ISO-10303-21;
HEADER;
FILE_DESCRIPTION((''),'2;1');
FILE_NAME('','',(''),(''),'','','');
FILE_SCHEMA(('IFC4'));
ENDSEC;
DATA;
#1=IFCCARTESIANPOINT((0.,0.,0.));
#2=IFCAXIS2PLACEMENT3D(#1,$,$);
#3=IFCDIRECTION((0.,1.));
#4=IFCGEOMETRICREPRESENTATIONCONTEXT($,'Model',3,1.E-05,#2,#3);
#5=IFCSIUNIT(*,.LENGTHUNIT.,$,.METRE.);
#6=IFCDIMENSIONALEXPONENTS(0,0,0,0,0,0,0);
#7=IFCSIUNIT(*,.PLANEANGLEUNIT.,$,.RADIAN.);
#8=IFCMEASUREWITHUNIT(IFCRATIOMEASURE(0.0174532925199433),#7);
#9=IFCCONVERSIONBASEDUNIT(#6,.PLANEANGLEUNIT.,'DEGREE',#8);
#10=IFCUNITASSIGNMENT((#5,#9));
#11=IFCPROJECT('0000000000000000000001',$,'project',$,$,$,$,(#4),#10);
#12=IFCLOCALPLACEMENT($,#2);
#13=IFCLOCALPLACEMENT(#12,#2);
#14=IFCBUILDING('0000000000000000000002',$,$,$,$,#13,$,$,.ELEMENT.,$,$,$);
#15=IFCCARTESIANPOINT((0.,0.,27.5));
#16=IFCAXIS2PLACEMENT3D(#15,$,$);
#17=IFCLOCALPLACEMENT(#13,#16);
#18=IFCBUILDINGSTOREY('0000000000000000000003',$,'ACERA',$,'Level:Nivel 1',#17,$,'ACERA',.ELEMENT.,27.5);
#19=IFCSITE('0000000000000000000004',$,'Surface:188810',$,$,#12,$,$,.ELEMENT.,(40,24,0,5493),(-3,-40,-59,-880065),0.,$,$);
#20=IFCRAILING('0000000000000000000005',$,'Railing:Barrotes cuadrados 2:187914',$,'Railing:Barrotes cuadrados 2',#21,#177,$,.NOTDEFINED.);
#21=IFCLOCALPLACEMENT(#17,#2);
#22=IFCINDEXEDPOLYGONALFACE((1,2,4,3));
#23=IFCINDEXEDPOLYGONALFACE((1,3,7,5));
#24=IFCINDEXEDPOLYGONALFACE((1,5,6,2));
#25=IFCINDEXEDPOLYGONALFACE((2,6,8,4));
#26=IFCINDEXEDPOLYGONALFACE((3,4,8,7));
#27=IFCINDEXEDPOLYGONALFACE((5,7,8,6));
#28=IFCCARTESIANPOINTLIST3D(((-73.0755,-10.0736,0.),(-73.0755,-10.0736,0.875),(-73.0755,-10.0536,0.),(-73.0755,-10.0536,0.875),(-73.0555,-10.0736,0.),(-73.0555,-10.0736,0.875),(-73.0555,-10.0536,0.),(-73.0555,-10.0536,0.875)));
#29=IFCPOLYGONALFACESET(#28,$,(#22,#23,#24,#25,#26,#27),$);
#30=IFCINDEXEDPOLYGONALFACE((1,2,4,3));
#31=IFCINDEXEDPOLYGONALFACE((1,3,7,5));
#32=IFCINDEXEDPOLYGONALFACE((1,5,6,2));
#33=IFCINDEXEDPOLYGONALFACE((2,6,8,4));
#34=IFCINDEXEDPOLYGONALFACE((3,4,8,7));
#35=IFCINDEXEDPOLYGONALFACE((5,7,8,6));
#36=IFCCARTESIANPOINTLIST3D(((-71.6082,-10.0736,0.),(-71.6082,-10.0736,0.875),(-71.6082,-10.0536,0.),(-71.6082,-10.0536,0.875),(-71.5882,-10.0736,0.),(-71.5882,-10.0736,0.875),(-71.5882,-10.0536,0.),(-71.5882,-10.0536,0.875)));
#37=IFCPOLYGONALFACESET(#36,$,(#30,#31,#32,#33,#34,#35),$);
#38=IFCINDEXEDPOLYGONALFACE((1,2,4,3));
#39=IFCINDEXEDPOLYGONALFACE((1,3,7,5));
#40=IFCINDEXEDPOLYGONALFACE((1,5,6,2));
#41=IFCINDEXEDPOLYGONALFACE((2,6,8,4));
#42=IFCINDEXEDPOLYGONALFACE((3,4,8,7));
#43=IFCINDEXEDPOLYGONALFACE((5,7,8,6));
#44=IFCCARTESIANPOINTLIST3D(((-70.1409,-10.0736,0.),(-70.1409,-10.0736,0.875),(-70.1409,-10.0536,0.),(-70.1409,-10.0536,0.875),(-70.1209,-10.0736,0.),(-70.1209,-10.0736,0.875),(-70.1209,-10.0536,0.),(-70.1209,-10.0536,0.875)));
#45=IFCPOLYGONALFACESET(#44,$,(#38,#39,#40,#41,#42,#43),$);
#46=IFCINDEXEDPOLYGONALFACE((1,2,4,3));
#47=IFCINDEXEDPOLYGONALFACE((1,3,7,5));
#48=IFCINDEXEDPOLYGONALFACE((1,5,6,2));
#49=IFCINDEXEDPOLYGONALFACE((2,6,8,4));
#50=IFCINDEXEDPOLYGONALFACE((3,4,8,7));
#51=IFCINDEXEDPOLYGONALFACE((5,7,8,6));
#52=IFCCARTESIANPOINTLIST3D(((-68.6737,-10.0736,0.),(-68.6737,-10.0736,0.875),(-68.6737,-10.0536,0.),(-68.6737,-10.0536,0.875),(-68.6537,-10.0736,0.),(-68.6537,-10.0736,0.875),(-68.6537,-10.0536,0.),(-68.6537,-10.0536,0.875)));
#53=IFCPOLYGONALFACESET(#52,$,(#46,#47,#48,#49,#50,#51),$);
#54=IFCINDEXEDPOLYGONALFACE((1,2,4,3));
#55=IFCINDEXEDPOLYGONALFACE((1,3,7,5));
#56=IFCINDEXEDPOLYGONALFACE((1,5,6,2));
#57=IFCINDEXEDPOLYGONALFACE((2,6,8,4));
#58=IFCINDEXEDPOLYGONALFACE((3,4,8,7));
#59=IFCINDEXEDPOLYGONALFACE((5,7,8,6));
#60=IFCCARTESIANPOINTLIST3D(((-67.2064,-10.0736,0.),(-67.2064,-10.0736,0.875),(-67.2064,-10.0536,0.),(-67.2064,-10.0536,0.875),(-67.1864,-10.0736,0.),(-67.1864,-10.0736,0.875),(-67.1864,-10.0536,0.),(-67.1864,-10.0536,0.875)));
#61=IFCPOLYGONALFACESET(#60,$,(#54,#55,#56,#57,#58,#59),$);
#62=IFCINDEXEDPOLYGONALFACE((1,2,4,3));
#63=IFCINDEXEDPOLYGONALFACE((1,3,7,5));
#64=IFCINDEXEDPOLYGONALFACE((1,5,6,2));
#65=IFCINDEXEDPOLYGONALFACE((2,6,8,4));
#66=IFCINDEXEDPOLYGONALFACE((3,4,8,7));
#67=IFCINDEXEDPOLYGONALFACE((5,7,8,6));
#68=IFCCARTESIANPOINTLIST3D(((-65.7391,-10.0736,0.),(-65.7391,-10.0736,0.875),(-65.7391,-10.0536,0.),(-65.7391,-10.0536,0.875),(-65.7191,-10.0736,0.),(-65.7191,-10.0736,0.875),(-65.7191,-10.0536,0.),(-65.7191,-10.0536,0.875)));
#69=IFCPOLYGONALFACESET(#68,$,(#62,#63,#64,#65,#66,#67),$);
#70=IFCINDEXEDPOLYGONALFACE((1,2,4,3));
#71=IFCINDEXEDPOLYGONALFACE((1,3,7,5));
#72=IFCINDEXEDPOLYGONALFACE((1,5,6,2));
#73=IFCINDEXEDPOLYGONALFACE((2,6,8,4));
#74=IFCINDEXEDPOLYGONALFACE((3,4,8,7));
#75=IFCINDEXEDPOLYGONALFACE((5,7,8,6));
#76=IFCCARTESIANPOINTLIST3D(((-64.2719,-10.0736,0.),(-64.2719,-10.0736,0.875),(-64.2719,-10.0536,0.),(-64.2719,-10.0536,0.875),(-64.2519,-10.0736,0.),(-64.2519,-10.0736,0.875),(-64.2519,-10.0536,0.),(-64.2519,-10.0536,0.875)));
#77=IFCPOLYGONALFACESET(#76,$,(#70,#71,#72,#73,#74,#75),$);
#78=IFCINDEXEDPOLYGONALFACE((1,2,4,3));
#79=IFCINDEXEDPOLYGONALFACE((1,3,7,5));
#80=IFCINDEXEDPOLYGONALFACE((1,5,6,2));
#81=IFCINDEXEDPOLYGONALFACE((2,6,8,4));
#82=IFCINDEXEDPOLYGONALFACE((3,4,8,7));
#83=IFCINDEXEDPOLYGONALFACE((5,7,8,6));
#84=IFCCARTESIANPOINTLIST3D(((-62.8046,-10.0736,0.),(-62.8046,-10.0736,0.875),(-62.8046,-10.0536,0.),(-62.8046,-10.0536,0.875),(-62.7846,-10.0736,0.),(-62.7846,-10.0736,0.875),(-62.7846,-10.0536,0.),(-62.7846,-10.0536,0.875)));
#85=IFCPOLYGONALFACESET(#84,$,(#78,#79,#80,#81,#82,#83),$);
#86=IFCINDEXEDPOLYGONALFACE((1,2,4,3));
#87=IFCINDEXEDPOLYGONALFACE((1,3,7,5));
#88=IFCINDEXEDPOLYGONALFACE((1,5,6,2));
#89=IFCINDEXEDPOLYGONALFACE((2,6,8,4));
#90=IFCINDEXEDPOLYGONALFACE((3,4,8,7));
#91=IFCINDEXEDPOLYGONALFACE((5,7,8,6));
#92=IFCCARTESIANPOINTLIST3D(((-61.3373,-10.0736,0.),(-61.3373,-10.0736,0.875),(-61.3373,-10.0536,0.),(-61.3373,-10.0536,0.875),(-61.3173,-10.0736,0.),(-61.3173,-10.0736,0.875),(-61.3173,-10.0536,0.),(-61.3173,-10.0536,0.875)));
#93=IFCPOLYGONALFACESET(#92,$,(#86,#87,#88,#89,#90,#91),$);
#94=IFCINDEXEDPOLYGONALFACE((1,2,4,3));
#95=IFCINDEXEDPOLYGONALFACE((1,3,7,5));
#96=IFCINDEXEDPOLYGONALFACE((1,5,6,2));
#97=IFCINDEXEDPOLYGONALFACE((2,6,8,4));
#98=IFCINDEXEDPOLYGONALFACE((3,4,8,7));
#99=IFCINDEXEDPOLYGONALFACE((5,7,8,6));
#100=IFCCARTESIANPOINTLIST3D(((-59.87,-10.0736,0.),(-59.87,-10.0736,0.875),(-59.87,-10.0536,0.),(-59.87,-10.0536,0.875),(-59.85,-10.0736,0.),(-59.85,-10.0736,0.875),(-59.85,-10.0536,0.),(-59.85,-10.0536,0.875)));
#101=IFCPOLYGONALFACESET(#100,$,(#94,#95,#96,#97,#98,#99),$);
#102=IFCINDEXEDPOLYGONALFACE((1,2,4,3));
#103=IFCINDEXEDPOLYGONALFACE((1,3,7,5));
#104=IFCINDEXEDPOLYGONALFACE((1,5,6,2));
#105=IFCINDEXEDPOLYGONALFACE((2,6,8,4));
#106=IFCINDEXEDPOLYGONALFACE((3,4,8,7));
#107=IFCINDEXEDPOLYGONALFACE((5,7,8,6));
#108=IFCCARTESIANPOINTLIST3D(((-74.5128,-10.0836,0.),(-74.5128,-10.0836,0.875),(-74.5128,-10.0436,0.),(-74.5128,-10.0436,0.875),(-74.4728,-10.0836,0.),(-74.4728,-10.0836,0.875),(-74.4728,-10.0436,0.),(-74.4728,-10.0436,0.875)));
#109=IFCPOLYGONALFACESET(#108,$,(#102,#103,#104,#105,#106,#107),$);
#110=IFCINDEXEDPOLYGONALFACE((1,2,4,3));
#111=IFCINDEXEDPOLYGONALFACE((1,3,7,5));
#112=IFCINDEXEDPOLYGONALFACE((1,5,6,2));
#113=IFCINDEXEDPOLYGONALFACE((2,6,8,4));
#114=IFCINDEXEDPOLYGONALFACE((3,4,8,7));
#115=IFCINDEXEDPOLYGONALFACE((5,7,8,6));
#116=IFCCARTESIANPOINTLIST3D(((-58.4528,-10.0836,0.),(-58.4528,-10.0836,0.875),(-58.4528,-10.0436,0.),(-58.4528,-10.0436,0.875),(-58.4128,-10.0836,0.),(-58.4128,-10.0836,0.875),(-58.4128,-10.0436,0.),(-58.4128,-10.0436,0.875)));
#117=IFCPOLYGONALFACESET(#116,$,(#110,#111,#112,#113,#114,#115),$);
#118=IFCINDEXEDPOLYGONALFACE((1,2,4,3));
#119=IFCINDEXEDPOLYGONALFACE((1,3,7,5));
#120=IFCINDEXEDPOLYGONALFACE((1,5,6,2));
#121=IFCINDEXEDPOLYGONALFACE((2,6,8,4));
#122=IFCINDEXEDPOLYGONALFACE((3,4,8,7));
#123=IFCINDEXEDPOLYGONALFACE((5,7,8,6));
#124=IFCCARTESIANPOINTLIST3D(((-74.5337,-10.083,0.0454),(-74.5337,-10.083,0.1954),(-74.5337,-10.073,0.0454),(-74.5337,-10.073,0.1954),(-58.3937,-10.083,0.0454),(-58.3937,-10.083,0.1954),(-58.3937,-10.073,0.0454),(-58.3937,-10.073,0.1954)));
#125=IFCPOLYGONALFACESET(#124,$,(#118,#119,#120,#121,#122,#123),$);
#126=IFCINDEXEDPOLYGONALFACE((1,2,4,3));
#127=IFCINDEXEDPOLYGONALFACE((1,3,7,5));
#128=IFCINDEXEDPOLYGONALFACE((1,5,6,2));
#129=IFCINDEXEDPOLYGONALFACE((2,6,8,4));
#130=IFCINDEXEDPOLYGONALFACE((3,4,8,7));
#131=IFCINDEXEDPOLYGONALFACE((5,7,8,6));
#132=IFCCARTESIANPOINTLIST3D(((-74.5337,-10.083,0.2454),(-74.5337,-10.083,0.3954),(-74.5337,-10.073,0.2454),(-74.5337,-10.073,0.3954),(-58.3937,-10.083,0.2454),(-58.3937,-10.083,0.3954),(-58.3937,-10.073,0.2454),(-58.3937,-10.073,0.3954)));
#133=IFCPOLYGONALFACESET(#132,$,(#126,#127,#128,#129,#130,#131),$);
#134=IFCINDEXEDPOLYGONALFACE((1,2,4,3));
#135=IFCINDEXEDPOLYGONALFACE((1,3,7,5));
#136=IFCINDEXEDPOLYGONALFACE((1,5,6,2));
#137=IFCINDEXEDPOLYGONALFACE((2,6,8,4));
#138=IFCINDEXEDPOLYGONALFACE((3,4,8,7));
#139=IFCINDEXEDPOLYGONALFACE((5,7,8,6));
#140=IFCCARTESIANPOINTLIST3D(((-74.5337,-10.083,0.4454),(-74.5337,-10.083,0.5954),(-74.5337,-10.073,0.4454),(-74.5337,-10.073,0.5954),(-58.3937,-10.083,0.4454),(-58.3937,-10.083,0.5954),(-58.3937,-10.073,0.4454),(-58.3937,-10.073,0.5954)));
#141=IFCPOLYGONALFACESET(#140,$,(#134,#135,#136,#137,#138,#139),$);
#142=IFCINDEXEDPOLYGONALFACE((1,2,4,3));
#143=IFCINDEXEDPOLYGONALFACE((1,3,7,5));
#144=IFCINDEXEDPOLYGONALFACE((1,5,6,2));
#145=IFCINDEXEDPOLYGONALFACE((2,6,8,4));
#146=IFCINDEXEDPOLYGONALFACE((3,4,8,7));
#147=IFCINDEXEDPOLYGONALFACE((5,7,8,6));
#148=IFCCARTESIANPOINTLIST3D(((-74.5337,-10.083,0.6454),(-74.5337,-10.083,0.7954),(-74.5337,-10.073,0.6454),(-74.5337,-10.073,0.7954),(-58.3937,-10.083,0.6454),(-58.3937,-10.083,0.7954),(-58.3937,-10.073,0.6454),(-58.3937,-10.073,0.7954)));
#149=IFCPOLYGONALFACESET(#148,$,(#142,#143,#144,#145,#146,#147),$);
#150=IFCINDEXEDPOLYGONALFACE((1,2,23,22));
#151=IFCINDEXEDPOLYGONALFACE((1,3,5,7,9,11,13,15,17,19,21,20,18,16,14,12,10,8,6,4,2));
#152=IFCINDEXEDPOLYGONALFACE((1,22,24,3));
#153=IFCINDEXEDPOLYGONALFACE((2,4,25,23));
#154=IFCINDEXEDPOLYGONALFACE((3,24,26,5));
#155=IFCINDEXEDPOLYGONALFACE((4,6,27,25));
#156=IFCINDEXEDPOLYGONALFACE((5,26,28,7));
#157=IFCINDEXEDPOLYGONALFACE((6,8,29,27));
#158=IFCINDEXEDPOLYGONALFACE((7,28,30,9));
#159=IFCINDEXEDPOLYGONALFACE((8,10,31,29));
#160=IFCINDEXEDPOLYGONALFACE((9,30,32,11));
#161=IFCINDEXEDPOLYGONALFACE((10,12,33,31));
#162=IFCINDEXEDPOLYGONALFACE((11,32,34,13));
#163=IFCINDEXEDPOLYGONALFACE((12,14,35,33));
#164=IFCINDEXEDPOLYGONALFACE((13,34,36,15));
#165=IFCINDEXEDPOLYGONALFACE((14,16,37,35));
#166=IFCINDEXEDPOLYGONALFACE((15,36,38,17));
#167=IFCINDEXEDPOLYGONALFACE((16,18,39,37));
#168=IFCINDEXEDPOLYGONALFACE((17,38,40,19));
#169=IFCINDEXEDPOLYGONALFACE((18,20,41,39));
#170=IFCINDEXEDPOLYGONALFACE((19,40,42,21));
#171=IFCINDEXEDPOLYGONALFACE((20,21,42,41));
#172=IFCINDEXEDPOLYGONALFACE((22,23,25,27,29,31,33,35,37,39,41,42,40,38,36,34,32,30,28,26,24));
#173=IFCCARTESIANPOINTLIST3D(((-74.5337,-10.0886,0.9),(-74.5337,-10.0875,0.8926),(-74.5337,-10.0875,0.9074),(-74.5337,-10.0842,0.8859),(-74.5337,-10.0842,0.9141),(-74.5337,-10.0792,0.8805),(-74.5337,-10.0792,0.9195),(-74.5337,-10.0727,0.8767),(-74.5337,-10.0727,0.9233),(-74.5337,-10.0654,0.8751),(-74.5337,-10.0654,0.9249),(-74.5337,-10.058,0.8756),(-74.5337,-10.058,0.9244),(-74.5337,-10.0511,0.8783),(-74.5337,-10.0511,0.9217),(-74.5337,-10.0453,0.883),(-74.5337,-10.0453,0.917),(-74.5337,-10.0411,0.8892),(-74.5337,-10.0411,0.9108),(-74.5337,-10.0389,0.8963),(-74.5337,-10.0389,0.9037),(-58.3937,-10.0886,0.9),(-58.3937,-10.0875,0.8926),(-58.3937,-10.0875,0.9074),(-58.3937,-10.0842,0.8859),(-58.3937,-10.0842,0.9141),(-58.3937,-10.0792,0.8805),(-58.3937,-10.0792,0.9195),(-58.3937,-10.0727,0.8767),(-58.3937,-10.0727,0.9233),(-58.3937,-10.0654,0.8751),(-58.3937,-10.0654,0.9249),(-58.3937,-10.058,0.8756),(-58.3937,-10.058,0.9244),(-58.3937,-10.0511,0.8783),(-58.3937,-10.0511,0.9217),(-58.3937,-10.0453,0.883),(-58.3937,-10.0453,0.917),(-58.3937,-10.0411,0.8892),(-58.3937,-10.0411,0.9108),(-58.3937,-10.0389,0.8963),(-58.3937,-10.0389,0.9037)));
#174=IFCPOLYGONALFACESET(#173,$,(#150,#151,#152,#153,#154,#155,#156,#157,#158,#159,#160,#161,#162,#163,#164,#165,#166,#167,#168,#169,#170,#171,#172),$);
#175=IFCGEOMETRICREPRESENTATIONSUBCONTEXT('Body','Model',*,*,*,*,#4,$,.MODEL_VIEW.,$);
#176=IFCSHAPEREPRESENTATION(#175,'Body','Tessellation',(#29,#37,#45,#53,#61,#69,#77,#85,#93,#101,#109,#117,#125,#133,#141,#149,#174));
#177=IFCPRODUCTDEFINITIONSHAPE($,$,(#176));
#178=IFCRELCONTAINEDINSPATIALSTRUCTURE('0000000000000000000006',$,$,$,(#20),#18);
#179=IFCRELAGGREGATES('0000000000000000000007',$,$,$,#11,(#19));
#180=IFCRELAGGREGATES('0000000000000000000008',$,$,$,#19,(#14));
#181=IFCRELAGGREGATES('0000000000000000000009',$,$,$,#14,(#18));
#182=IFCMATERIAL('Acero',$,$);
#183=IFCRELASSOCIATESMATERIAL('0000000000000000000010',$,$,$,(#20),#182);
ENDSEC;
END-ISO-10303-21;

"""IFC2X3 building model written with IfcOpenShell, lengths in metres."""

from ifc_helpers import new_model, entity, si_unit, converted_unit, direction, frame, frame_2d, origin, origin_2d_with_axis, place, context, subcontext, project, spatial, rectangle, circle, extrude, material, element, save


model = new_model("IFC2X3")

# Units and contexts
model_context = context("Model", 3, precision=1e-05, world=origin(), true_north=direction((0.0, 1.0)))
body_context = subcontext(model_context, "Body", "Model", "MODEL_VIEW")
ifc_project = project(units=[si_unit("LENGTHUNIT", "METRE"), converted_unit("PLANEANGLEUNIT", "DEGREE", entity("IfcRatioMeasure", 0.0174532925199433), si_unit("PLANEANGLEUNIT", "RADIAN"), dimensions=[0, 0, 0, 0, 0, 0, 0])], contexts=[model_context])

# Site, building, storey
site_placement = place(None, origin())
site = spatial("IfcSite", under=ifc_project, at=site_placement, Name="Surface:188810", CompositionType="ELEMENT", RefLatitude=(40, 24, 0, 5493), RefLongitude=(-3, -40, -59, -880065), RefElevation=0.0)
building_placement = place(site_placement, origin())
building = spatial("IfcBuilding", under=site, at=building_placement, CompositionType="ELEMENT")
storey_placement = place(building_placement, frame((0.0, 0.0, 27.5)))
storey = spatial("IfcBuildingStorey", under=building, at=storey_placement, Name="ACERA", ObjectType="Level:Nivel 1", LongName="ACERA", CompositionType="ELEMENT", Elevation=27.5)

# Railing
ifc_material_1 = material(Name="Acero")
railing_1_placement = place(storey_placement, origin())
element("IfcRailing", 1, at=railing_1_placement, inside=storey, material=ifc_material_1, Name="Railing:Barrotes cuadrados 2:187914", ObjectType="Railing:Barrotes cuadrados 2", PredefinedType="NOTDEFINED", context=body_context, shape_type="SweptSolid", body=[
    extrude(rectangle(XDim=0.02, YDim=0.02, at=frame_2d((0.0, 0.0), x_axis=(1.0, 0.0))), frame((-73.0655, -10.0636, 0.0), z_axis=(0.0, 0.0, 1.0), x_axis=(-1.0, 0.0, 0.0)), (0.0, 0.0, 1.0), 0.875),
    extrude(rectangle(XDim=0.02, YDim=0.02, at=frame_2d((0.0, 0.0), x_axis=(1.0, 0.0))), frame((-71.5982, -10.0636, 0.0), z_axis=(0.0, 0.0, 1.0), x_axis=(-1.0, 0.0, 0.0)), (0.0, 0.0, 1.0), 0.875),
    extrude(rectangle(XDim=0.02, YDim=0.02, at=frame_2d((0.0, 0.0), x_axis=(1.0, 0.0))), frame((-70.1309, -10.0636, 0.0), z_axis=(0.0, 0.0, 1.0), x_axis=(-1.0, 0.0, 0.0)), (0.0, 0.0, 1.0), 0.875),
    extrude(rectangle(XDim=0.02, YDim=0.02, at=frame_2d((0.0, 0.0), x_axis=(1.0, 0.0))), frame((-68.6637, -10.0636, 0.0), z_axis=(0.0, 0.0, 1.0), x_axis=(-1.0, 0.0, 0.0)), (0.0, 0.0, 1.0), 0.875),
    extrude(rectangle(XDim=0.02, YDim=0.02, at=frame_2d((0.0, 0.0), x_axis=(1.0, 0.0))), frame((-67.1964, -10.0636, 0.0), z_axis=(0.0, 0.0, 1.0), x_axis=(-1.0, 0.0, 0.0)), (0.0, 0.0, 1.0), 0.875),
    extrude(rectangle(XDim=0.02, YDim=0.02, at=frame_2d((0.0, 0.0), x_axis=(1.0, 0.0))), frame((-65.7291, -10.0636, 0.0), z_axis=(0.0, 0.0, 1.0), x_axis=(-1.0, 0.0, 0.0)), (0.0, 0.0, 1.0), 0.875),
    extrude(rectangle(XDim=0.02, YDim=0.02, at=frame_2d((0.0, 0.0), x_axis=(1.0, 0.0))), frame((-64.2619, -10.0636, 0.0), z_axis=(0.0, 0.0, 1.0), x_axis=(-1.0, 0.0, 0.0)), (0.0, 0.0, 1.0), 0.875),
    extrude(rectangle(XDim=0.02, YDim=0.02, at=frame_2d((0.0, 0.0), x_axis=(1.0, 0.0))), frame((-62.7946, -10.0636, 0.0), z_axis=(0.0, 0.0, 1.0), x_axis=(-1.0, 0.0, 0.0)), (0.0, 0.0, 1.0), 0.875),
    extrude(rectangle(XDim=0.02, YDim=0.02, at=frame_2d((0.0, 0.0), x_axis=(1.0, 0.0))), frame((-61.3273, -10.0636, 0.0), z_axis=(0.0, 0.0, 1.0), x_axis=(-1.0, 0.0, 0.0)), (0.0, 0.0, 1.0), 0.875),
    extrude(rectangle(XDim=0.02, YDim=0.02, at=frame_2d((0.0, 0.0), x_axis=(1.0, 0.0))), frame((-59.86, -10.0636, 0.0), z_axis=(0.0, 0.0, 1.0), x_axis=(-1.0, 0.0, 0.0)), (0.0, 0.0, 1.0), 0.875),
    extrude(rectangle(XDim=0.04, YDim=0.04, at=frame_2d((0.0, 0.0), x_axis=(1.0, 0.0))), frame((-74.4928, -10.0636, 0.0), z_axis=(0.0, 0.0, 1.0), x_axis=(-1.0, 0.0, 0.0)), (0.0, 0.0, 1.0), 0.875),
    extrude(rectangle(XDim=0.04, YDim=0.04, at=frame_2d((0.0, 0.0), x_axis=(1.0, 0.0))), frame((-58.4328, -10.0636, 0.0), z_axis=(0.0, 0.0, 1.0), x_axis=(-1.0, 0.0, 0.0)), (0.0, 0.0, 1.0), 0.875),
    extrude(rectangle(XDim=16.14, YDim=0.01, at=frame_2d((0.0, 0.0), x_axis=(1.0, 0.0))), frame((-66.4637, -10.078, 0.0454), z_axis=(0.0, 0.0, 1.0), x_axis=(-1.0, 0.0, 0.0)), (0.0, 0.0, 1.0), 0.15),
    extrude(rectangle(XDim=16.14, YDim=0.01, at=frame_2d((0.0, 0.0), x_axis=(1.0, 0.0))), frame((-66.4637, -10.078, 0.2454), z_axis=(0.0, 0.0, 1.0), x_axis=(-1.0, 0.0, 0.0)), (0.0, 0.0, 1.0), 0.15),
    extrude(rectangle(XDim=16.14, YDim=0.01, at=frame_2d((0.0, 0.0), x_axis=(1.0, 0.0))), frame((-66.4637, -10.078, 0.4454), z_axis=(0.0, 0.0, 1.0), x_axis=(-1.0, 0.0, 0.0)), (0.0, 0.0, 1.0), 0.15),
    extrude(rectangle(XDim=16.14, YDim=0.01, at=frame_2d((0.0, 0.0), x_axis=(1.0, 0.0))), frame((-66.4637, -10.078, 0.6454), z_axis=(0.0, 0.0, 1.0), x_axis=(-1.0, 0.0, 0.0)), (0.0, 0.0, 1.0), 0.15),
    extrude(circle(Radius=0.025, at=origin_2d_with_axis()), frame((-74.5337, -10.0636, 0.9), z_axis=(1.0, 0.0, 0.0), x_axis=(0.0, -1.0, 0.0)), (0.0, 0.0, 1.0), 16.14),
])

save(model, "model.ifc")
